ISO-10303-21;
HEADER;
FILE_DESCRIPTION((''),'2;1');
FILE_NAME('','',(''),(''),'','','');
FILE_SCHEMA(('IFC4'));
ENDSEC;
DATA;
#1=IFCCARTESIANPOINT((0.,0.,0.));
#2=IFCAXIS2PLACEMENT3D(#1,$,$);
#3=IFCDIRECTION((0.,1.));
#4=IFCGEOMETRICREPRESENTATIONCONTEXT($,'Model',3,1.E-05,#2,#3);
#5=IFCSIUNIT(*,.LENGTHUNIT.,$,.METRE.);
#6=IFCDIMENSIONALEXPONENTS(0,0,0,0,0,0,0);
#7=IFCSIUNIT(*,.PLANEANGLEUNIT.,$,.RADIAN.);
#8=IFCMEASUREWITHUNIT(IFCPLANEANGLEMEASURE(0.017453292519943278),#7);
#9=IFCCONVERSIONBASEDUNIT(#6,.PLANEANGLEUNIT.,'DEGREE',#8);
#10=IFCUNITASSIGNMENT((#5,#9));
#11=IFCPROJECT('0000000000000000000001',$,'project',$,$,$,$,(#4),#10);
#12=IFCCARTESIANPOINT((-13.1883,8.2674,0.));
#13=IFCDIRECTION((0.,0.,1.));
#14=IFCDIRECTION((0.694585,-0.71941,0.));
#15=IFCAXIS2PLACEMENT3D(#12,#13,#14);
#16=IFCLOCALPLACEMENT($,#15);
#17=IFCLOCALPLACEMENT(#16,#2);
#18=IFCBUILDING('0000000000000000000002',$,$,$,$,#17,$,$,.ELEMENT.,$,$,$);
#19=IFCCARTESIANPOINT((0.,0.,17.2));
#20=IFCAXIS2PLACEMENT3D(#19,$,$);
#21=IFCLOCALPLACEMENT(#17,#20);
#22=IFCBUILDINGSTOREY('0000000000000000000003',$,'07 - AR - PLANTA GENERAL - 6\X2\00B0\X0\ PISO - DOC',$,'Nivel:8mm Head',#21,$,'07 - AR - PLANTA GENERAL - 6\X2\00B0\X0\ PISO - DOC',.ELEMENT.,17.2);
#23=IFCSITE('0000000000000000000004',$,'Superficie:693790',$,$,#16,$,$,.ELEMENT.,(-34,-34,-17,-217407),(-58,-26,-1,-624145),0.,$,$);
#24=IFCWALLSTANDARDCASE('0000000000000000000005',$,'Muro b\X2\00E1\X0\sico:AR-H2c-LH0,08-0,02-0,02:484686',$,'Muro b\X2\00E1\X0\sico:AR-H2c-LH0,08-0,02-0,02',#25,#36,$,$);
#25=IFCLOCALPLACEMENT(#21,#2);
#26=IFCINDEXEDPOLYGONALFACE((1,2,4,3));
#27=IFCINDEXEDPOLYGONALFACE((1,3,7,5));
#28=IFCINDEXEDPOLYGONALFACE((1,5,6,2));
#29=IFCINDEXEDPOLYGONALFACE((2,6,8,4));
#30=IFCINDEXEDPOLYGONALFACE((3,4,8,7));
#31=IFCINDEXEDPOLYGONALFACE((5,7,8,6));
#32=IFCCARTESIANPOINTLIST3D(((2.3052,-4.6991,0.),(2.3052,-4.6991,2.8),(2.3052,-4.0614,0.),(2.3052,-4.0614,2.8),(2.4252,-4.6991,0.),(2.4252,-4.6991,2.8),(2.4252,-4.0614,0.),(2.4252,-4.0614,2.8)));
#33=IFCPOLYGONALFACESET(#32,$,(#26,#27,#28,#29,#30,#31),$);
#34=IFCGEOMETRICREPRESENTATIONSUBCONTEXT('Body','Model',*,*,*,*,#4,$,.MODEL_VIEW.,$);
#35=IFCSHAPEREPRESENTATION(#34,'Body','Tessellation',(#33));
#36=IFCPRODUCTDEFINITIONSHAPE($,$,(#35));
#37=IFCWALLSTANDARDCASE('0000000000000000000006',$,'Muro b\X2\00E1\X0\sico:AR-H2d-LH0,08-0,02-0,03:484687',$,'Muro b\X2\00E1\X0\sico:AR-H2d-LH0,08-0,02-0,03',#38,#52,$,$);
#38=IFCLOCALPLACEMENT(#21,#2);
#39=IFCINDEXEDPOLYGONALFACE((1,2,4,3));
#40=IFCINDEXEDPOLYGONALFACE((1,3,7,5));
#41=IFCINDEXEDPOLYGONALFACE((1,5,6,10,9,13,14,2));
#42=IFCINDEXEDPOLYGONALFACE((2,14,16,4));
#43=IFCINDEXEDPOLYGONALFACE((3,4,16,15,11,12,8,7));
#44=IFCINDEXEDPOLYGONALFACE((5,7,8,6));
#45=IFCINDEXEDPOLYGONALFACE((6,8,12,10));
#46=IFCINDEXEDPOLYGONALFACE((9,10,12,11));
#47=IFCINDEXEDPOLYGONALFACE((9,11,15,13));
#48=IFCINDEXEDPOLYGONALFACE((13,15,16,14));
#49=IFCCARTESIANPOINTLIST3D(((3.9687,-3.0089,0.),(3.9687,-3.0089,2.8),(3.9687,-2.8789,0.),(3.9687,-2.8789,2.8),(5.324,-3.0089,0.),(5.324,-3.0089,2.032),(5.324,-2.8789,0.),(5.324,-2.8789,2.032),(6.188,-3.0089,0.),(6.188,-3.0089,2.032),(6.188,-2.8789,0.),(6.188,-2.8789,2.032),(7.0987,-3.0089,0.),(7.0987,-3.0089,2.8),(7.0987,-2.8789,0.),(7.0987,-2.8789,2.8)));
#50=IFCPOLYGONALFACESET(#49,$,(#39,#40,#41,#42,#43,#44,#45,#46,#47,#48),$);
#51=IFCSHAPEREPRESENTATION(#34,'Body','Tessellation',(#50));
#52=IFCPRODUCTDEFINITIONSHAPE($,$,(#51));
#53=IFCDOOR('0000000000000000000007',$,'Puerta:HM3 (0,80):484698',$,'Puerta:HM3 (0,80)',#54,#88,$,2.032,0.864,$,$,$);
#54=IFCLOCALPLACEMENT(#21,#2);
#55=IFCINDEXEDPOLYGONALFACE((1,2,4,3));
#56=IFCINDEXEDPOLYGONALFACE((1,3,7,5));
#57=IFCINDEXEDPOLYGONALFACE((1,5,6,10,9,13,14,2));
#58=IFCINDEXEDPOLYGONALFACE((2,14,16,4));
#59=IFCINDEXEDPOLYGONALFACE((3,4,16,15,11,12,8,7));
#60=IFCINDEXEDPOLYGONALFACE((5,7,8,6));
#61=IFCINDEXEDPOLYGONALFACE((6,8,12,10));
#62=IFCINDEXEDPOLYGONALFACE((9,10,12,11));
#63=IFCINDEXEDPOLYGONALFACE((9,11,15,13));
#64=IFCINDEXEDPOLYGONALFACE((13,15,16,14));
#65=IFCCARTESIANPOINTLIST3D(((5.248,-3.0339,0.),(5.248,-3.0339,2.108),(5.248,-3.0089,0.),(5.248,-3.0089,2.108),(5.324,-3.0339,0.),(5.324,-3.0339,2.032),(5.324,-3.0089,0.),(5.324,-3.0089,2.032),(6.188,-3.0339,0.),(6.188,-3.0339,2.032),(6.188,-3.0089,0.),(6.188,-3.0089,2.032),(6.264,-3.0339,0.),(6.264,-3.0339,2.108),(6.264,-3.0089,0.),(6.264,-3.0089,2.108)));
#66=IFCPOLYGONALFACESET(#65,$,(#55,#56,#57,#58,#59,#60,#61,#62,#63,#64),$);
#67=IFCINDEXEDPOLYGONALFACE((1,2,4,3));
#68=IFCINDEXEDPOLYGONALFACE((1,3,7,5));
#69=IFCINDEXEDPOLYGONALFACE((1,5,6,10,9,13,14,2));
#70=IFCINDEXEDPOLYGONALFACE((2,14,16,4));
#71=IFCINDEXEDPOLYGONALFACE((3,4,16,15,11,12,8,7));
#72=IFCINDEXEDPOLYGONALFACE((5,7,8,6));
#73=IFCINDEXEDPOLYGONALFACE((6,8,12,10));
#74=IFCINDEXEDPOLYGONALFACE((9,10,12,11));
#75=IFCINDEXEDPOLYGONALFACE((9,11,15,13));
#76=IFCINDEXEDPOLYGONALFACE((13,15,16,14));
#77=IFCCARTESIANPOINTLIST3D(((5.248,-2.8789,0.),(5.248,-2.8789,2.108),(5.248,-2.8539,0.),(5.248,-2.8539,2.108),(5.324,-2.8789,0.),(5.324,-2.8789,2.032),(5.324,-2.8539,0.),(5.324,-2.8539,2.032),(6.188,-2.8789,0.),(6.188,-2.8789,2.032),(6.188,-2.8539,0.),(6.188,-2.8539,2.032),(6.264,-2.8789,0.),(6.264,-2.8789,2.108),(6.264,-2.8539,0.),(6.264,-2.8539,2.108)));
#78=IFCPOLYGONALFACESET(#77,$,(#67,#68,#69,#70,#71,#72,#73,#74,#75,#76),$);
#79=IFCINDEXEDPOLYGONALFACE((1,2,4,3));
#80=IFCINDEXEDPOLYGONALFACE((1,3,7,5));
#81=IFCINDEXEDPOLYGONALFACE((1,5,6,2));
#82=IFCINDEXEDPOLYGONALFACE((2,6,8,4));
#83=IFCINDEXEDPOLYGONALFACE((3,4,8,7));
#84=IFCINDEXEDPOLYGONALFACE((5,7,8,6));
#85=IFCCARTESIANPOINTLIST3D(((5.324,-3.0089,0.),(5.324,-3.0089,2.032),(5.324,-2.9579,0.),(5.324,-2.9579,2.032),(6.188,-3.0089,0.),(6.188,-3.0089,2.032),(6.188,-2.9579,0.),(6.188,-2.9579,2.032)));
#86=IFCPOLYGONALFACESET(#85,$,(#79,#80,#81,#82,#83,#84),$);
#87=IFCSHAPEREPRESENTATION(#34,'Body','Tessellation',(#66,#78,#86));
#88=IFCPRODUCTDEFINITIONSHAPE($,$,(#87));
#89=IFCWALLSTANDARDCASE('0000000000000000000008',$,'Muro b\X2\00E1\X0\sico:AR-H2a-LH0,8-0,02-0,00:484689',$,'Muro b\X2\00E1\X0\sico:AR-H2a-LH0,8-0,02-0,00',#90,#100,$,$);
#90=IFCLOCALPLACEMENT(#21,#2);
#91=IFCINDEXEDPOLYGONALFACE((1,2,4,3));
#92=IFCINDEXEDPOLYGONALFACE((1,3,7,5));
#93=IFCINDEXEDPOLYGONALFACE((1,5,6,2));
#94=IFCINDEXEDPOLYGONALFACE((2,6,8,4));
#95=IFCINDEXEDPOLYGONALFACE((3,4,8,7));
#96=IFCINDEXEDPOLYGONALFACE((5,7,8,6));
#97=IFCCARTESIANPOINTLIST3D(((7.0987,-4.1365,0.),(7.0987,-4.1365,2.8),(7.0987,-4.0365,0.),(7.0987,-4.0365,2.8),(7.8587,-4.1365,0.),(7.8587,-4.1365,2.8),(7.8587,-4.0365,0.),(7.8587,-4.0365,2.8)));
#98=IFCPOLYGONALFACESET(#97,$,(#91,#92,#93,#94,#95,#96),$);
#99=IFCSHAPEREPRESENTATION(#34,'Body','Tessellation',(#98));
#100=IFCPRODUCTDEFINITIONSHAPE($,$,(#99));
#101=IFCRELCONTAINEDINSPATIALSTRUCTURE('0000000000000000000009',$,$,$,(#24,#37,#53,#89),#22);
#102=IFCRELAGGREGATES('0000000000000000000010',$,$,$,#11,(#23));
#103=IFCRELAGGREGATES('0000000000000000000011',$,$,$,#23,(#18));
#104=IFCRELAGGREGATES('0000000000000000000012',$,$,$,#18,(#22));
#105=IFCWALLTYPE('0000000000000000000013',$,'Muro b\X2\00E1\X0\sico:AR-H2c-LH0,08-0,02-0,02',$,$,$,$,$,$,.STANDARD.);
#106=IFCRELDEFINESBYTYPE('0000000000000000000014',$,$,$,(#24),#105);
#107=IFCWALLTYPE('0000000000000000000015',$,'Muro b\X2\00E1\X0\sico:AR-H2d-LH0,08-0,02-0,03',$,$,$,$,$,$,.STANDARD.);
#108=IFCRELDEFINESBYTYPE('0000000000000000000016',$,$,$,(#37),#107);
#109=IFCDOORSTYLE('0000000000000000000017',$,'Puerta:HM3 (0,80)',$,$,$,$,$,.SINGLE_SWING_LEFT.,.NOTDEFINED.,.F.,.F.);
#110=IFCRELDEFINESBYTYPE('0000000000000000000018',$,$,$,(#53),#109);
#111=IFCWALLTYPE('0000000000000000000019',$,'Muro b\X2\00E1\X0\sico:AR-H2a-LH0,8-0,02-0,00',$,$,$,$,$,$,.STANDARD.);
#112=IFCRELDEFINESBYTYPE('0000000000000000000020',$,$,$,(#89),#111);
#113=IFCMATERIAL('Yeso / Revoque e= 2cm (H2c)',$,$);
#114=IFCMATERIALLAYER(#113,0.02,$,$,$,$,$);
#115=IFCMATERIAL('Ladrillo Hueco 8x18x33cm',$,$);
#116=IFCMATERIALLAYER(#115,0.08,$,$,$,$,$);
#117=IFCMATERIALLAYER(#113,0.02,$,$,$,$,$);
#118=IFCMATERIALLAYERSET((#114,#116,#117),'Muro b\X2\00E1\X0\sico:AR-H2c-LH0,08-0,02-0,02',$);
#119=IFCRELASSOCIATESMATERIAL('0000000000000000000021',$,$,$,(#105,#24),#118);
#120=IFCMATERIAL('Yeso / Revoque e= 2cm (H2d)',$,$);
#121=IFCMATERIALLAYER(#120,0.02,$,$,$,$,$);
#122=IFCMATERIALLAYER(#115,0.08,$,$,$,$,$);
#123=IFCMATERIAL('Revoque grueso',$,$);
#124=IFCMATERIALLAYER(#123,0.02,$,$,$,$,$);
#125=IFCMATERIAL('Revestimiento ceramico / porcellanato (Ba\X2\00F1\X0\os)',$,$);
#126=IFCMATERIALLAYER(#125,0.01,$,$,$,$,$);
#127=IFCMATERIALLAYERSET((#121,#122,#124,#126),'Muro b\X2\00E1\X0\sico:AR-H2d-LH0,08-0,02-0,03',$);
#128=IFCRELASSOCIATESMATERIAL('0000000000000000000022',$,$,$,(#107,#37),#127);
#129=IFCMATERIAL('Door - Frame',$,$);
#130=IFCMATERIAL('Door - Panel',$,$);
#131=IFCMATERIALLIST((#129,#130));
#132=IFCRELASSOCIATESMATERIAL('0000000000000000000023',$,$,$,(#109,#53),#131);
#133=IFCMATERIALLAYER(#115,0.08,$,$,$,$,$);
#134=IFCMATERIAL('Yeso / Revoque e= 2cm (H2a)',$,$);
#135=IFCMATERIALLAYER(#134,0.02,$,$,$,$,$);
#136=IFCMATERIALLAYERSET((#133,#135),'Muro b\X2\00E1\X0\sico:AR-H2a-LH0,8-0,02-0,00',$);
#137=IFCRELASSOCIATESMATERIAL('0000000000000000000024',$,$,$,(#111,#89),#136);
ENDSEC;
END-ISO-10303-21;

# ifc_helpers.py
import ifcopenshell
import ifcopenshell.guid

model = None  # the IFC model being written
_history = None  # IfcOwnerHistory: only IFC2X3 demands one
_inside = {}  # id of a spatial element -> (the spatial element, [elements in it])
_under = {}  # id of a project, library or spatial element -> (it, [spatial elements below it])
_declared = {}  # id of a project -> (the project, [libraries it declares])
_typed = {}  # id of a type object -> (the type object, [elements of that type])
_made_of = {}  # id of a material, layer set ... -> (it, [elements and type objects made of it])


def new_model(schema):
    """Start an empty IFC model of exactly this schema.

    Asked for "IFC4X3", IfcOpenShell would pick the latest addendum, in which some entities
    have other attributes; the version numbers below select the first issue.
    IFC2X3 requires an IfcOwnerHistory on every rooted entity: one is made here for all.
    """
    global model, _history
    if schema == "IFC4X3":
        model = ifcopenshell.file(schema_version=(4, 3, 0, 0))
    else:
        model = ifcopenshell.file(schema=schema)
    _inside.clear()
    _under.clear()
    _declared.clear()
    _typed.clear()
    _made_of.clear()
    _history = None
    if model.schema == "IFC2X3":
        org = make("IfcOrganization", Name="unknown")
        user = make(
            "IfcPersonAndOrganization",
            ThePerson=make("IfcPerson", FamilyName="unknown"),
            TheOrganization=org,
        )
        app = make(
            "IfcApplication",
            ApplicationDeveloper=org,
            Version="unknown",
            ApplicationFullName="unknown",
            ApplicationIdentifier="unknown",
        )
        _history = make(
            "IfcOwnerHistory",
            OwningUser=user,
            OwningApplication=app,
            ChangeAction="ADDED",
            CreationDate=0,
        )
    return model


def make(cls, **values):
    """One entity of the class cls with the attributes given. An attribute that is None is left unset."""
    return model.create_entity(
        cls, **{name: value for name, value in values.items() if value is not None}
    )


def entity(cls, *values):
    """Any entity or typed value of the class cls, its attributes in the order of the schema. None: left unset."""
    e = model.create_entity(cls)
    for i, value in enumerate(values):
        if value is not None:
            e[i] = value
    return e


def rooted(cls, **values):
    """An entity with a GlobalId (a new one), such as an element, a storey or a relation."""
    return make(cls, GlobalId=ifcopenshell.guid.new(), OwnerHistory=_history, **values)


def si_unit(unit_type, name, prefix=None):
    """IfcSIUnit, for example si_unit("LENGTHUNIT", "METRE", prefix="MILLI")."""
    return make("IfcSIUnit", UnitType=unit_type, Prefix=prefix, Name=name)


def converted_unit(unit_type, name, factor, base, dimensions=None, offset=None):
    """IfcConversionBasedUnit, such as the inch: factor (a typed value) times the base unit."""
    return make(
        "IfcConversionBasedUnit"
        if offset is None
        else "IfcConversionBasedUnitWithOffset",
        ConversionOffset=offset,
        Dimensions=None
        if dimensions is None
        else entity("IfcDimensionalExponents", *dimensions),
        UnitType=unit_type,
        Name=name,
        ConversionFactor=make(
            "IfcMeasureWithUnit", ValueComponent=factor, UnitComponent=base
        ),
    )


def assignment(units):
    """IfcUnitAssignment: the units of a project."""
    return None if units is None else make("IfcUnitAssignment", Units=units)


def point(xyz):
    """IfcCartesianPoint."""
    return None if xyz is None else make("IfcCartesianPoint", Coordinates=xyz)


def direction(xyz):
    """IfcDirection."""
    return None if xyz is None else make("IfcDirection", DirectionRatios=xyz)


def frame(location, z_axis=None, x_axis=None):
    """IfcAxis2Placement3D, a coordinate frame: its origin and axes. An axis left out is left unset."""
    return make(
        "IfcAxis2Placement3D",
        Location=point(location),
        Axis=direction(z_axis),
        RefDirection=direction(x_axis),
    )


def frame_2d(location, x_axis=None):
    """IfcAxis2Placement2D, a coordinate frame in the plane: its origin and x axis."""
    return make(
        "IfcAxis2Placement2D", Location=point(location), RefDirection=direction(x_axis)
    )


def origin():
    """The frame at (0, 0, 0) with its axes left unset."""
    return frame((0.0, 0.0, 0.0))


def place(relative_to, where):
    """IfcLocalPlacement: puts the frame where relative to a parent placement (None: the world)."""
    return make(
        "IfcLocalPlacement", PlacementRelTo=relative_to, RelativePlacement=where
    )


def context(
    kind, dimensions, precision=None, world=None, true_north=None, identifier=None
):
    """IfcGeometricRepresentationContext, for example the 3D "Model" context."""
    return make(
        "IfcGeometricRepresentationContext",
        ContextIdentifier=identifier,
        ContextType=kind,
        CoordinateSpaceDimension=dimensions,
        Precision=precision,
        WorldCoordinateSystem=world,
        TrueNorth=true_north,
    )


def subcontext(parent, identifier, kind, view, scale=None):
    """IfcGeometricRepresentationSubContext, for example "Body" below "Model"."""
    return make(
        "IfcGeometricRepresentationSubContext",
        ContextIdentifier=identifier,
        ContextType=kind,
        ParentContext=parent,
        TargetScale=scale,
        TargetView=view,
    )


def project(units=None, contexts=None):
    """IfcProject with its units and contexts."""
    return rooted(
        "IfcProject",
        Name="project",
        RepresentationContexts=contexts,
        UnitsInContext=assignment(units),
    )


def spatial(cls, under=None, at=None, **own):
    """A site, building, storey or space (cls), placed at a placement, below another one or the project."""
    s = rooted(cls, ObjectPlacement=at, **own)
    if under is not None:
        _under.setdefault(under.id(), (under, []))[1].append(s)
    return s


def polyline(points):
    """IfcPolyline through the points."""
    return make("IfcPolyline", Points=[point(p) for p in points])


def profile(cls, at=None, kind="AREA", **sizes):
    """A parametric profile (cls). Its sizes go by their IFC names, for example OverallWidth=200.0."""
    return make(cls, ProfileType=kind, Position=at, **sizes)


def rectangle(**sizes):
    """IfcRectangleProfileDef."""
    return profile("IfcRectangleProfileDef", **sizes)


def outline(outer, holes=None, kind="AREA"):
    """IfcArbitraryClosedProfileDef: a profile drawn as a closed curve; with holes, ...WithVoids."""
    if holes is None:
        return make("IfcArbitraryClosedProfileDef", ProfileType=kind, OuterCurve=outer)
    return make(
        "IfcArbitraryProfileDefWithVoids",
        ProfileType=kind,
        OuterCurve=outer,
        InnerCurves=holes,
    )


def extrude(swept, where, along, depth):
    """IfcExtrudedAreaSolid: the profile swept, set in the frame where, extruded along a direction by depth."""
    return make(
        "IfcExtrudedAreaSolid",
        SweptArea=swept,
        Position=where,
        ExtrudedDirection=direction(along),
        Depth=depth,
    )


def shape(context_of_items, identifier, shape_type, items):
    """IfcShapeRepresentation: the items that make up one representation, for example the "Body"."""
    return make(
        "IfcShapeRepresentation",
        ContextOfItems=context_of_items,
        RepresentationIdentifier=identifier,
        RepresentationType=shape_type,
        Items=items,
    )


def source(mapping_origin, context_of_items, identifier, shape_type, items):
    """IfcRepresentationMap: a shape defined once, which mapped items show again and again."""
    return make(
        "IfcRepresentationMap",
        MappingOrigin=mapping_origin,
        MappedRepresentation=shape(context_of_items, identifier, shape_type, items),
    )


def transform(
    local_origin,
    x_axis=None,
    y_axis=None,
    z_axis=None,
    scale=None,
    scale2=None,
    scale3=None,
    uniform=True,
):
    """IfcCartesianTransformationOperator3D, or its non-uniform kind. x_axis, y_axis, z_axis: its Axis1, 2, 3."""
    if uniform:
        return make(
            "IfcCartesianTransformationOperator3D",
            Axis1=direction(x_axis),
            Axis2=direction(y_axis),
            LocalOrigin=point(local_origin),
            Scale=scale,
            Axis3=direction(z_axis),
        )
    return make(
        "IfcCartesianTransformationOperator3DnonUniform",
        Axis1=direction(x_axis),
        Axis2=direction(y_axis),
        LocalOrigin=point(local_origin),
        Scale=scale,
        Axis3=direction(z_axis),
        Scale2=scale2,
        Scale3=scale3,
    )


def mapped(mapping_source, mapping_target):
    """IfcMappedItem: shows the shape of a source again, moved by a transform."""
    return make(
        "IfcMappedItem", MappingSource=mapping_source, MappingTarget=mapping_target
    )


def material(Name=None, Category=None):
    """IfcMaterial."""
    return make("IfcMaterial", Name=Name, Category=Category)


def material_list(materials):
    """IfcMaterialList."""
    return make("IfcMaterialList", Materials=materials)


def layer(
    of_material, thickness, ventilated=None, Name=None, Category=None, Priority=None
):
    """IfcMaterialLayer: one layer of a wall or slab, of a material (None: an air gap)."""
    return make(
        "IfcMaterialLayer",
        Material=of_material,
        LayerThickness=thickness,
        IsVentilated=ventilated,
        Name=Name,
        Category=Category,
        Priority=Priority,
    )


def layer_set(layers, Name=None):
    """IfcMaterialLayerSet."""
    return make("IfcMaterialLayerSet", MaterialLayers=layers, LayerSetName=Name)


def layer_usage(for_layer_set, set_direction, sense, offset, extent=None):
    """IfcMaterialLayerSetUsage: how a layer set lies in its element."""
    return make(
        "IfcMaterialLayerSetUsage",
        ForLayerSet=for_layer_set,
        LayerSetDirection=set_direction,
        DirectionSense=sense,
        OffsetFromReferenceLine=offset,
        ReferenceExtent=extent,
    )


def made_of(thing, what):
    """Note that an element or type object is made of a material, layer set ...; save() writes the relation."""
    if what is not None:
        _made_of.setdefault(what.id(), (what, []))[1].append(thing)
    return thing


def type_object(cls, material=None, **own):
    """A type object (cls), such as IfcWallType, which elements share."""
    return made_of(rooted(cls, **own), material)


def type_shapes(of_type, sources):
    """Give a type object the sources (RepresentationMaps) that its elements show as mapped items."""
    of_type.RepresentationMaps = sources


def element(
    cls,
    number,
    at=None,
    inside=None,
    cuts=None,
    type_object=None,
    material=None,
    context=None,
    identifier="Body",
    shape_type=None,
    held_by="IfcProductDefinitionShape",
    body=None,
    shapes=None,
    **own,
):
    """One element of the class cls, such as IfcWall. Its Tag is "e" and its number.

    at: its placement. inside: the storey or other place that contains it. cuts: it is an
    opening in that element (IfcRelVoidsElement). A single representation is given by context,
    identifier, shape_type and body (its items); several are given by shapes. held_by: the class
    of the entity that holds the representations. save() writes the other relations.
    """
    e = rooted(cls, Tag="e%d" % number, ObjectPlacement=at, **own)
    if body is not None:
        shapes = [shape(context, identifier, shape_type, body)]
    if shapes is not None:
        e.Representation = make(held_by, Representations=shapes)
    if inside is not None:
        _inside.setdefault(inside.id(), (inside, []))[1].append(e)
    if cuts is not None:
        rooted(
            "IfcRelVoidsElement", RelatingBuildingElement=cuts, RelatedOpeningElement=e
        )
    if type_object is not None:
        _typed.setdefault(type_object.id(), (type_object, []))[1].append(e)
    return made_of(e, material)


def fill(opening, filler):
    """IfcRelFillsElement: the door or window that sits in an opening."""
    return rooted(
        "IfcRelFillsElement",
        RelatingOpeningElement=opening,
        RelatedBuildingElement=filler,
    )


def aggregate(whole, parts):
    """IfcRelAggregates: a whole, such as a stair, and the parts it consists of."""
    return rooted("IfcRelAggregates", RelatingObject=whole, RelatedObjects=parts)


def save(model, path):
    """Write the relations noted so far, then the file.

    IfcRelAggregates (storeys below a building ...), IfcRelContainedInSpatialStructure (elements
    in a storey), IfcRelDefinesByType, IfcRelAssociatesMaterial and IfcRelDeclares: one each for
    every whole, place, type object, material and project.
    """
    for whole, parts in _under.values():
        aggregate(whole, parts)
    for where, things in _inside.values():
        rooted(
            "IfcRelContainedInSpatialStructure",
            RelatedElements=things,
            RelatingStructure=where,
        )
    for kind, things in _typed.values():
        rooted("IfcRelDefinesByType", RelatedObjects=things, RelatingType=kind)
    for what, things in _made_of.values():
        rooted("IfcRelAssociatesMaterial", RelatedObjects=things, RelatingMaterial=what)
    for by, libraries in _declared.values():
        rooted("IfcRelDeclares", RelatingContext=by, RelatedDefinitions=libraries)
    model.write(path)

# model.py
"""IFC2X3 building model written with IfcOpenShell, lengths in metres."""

from ifc_helpers import new_model, entity, si_unit, converted_unit, direction, frame, frame_2d, origin, place, context, subcontext, project, spatial, polyline, rectangle, outline, extrude, source, transform, mapped, material, material_list, layer, layer_set, layer_usage, type_object, type_shapes, element, fill, save


model = new_model("IFC2X3")

# Units and contexts
model_context = context("Model", 3, precision=1e-05, world=origin(), true_north=direction((0.0, 1.0)))
body_context = subcontext(model_context, "Body", "Model", "MODEL_VIEW")
ifc_project = project(units=[si_unit("LENGTHUNIT", "METRE"), converted_unit("PLANEANGLEUNIT", "DEGREE", entity("IfcPlaneAngleMeasure", 0.017453292519943278), si_unit("PLANEANGLEUNIT", "RADIAN"), dimensions=[0, 0, 0, 0, 0, 0, 0])], contexts=[model_context])

# Site, building, storey
site_placement = place(None, frame((-13.1883, 8.2674, 0.0), z_axis=(0.0, 0.0, 1.0), x_axis=(0.694585, -0.71941, 0.0)))
site = spatial("IfcSite", under=ifc_project, at=site_placement, Name="Superficie:693790", CompositionType="ELEMENT", RefLatitude=(-34, -34, -17, -217407), RefLongitude=(-58, -26, -1, -624145), RefElevation=0.0)
building_placement = place(site_placement, origin())
building = spatial("IfcBuilding", under=site, at=building_placement, CompositionType="ELEMENT")
storey_placement = place(building_placement, frame((0.0, 0.0, 17.2)))
storey = spatial("IfcBuildingStorey", under=building, at=storey_placement, Name="07 - AR - PLANTA GENERAL - 6° PISO - DOC", ObjectType="Nivel:8mm Head", LongName="07 - AR - PLANTA GENERAL - 6° PISO - DOC", CompositionType="ELEMENT", Elevation=17.2)

# Wall
ifc_material_1 = material(Name="Yeso / Revoque e= 2cm (H2c)")
ifc_layer_1 = layer(ifc_material_1, 0.02)
ifc_material_2 = material(Name="Ladrillo Hueco 8x18x33cm")
ifc_layer_2 = layer(ifc_material_2, 0.08)
ifc_layer_3 = layer(ifc_material_1, 0.02)
ifc_layer_set_1 = layer_set([ifc_layer_1, ifc_layer_2, ifc_layer_3], Name="Muro básico:AR-H2c-LH0,08-0,02-0,02")
ifc_layer_usage_1 = layer_usage(ifc_layer_set_1, "AXIS2", "POSITIVE", -0.06)
wall_type_1 = type_object("IfcWallType", Name="Muro básico:AR-H2c-LH0,08-0,02-0,02", PredefinedType="STANDARD", material=ifc_layer_set_1)
wall_1_placement = place(storey_placement, frame((2.3652, -4.0614, 0.0), z_axis=(0.0, 0.0, 1.0), x_axis=(0.0, -1.0, 0.0)))
element("IfcWallStandardCase", 1, at=wall_1_placement, inside=storey, type_object=wall_type_1, material=ifc_layer_usage_1, Name="Muro básico:AR-H2c-LH0,08-0,02-0,02:484686", ObjectType="Muro básico:AR-H2c-LH0,08-0,02-0,02", context=body_context, shape_type="SweptSolid", body=[
    extrude(rectangle(XDim=0.6377, YDim=0.12, at=frame_2d((0.3189, 0.0), x_axis=(-1.0, 0.0))), origin(), (0.0, 0.0, 1.0), 2.8),
])

# Wall, opening, door
ifc_material_3 = material(Name="Yeso / Revoque e= 2cm (H2d)")
ifc_layer_4 = layer(ifc_material_3, 0.02)
ifc_layer_5 = layer(ifc_material_2, 0.08)
ifc_material_4 = material(Name="Revoque grueso")
ifc_layer_6 = layer(ifc_material_4, 0.02)
ifc_material_5 = material(Name="Revestimiento ceramico / porcellanato (Baños)")
ifc_layer_7 = layer(ifc_material_5, 0.01)
ifc_layer_set_2 = layer_set([ifc_layer_4, ifc_layer_5, ifc_layer_6, ifc_layer_7], Name="Muro básico:AR-H2d-LH0,08-0,02-0,03")
ifc_layer_usage_2 = layer_usage(ifc_layer_set_2, "AXIS2", "NEGATIVE", 0.065)
wall_type_2 = type_object("IfcWallType", Name="Muro básico:AR-H2d-LH0,08-0,02-0,03", PredefinedType="STANDARD", material=ifc_layer_set_2)
wall_2_placement = place(storey_placement, frame((3.9687, -2.9439, 0.0)))
wall_2 = element("IfcWallStandardCase", 2, at=wall_2_placement, inside=storey, type_object=wall_type_2, material=ifc_layer_usage_2, Name="Muro básico:AR-H2d-LH0,08-0,02-0,03:484687", ObjectType="Muro básico:AR-H2d-LH0,08-0,02-0,03", context=body_context, shape_type="SweptSolid", body=[
    extrude(rectangle(XDim=3.13, YDim=0.13, at=frame_2d((1.565, 0.0), x_axis=(1.0, 0.0))), origin(), (0.0, 0.0, 1.0), 2.8),
])
opening_1_placement = place(wall_2_placement, frame((2.2193, 0.065, 0.0)))
opening_1 = element("IfcOpeningElement", 3, at=opening_1_placement, cuts=wall_2, ObjectType="Opening", context=body_context, shape_type="SweptSolid", body=[
    extrude(rectangle(XDim=0.864, YDim=2.032, at=frame_2d((1.016, 0.432), x_axis=(0.0, -1.0))), frame((0.0, 0.0, 0.0), z_axis=(0.0, -1.0, 0.0), x_axis=(0.0, 0.0, 1.0)), (0.0, 0.0, 1.0), 0.13),
])
ifc_material_6 = material(Name="Door - Frame")
ifc_material_7 = material(Name="Door - Panel")
ifc_material_list = material_list([ifc_material_6, ifc_material_7])
door_style_1 = type_object("IfcDoorStyle", Name="Puerta:HM3 (0,80)", ConstructionType="NOTDEFINED", OperationType="SINGLE_SWING_LEFT", ParameterTakesPrecedence=False, Sizeable=False, material=ifc_material_list)
shared_shape_1 = source(origin(), body_context, "Body", "SweptSolid", [
    extrude(outline(polyline([(-0.508, -1.073), (0.508, -1.073), (0.508, 1.035), (0.432, 1.035), (0.432, -0.997), (-0.432, -0.997), (-0.432, 1.035), (-0.508, 1.035), (-0.508, -1.073)])), frame((0.432, 0.155, 1.035), z_axis=(0.0, -1.0, 0.0), x_axis=(-1.0, 0.0, 0.0)), (0.0, 0.0, 1.0), 0.025),
    extrude(outline(polyline([(-1.073, -0.508), (1.035, -0.508), (1.035, -0.432), (-0.997, -0.432), (-0.997, 0.432), (1.035, 0.432), (1.035, 0.508), (-1.073, 0.508), (-1.073, -0.508)])), frame((0.432, 0.0, 1.035), z_axis=(0.0, -1.0, 0.0), x_axis=(0.0, 0.0, -1.0)), (0.0, 0.0, 1.0), 0.025),
    extrude(rectangle(XDim=0.864, YDim=0.051, at=frame_2d((0.0, 0.0), x_axis=(1.0, 0.0))), frame((0.432, 0.1045, 0.0)), (0.0, 0.0, 1.0), 2.032),
])
type_shapes(door_style_1, [shared_shape_1])
door_1_placement = place(opening_1_placement, frame((0.0, 0.0, 0.0), z_axis=(0.0, 0.0, 1.0), x_axis=(-1.0, 0.0, 0.0)))
door_1 = element("IfcDoor", 4, at=door_1_placement, inside=storey, type_object=door_style_1, material=ifc_material_list, Name="Puerta:HM3 (0,80):484698", ObjectType="Puerta:HM3 (0,80)", OverallHeight=2.032, OverallWidth=0.864, context=body_context, shape_type="MappedRepresentation", body=[
    mapped(shared_shape_1, transform((0.0, 0.0, 0.0), scale=1.0)),
])
fill(opening_1, door_1)

# Wall
ifc_layer_8 = layer(ifc_material_2, 0.08)
ifc_material_8 = material(Name="Yeso / Revoque e= 2cm (H2a)")
ifc_layer_9 = layer(ifc_material_8, 0.02)
ifc_layer_set_3 = layer_set([ifc_layer_8, ifc_layer_9], Name="Muro básico:AR-H2a-LH0,8-0,02-0,00")
ifc_layer_usage_3 = layer_usage(ifc_layer_set_3, "AXIS2", "POSITIVE", -0.05)
wall_type_3 = type_object("IfcWallType", Name="Muro básico:AR-H2a-LH0,8-0,02-0,00", PredefinedType="STANDARD", material=ifc_layer_set_3)
wall_3_placement = place(storey_placement, frame((7.0987, -4.0865, 0.0)))
element("IfcWallStandardCase", 5, at=wall_3_placement, inside=storey, type_object=wall_type_3, material=ifc_layer_usage_3, Name="Muro básico:AR-H2a-LH0,8-0,02-0,00:484689", ObjectType="Muro básico:AR-H2a-LH0,8-0,02-0,00", context=body_context, shape_type="SweptSolid", body=[
    extrude(rectangle(XDim=0.76, YDim=0.1, at=frame_2d((0.38, 0.0), x_axis=(-1.0, 0.0))), origin(), (0.0, 0.0, 1.0), 2.8),
])

save(model, "model.ifc")
